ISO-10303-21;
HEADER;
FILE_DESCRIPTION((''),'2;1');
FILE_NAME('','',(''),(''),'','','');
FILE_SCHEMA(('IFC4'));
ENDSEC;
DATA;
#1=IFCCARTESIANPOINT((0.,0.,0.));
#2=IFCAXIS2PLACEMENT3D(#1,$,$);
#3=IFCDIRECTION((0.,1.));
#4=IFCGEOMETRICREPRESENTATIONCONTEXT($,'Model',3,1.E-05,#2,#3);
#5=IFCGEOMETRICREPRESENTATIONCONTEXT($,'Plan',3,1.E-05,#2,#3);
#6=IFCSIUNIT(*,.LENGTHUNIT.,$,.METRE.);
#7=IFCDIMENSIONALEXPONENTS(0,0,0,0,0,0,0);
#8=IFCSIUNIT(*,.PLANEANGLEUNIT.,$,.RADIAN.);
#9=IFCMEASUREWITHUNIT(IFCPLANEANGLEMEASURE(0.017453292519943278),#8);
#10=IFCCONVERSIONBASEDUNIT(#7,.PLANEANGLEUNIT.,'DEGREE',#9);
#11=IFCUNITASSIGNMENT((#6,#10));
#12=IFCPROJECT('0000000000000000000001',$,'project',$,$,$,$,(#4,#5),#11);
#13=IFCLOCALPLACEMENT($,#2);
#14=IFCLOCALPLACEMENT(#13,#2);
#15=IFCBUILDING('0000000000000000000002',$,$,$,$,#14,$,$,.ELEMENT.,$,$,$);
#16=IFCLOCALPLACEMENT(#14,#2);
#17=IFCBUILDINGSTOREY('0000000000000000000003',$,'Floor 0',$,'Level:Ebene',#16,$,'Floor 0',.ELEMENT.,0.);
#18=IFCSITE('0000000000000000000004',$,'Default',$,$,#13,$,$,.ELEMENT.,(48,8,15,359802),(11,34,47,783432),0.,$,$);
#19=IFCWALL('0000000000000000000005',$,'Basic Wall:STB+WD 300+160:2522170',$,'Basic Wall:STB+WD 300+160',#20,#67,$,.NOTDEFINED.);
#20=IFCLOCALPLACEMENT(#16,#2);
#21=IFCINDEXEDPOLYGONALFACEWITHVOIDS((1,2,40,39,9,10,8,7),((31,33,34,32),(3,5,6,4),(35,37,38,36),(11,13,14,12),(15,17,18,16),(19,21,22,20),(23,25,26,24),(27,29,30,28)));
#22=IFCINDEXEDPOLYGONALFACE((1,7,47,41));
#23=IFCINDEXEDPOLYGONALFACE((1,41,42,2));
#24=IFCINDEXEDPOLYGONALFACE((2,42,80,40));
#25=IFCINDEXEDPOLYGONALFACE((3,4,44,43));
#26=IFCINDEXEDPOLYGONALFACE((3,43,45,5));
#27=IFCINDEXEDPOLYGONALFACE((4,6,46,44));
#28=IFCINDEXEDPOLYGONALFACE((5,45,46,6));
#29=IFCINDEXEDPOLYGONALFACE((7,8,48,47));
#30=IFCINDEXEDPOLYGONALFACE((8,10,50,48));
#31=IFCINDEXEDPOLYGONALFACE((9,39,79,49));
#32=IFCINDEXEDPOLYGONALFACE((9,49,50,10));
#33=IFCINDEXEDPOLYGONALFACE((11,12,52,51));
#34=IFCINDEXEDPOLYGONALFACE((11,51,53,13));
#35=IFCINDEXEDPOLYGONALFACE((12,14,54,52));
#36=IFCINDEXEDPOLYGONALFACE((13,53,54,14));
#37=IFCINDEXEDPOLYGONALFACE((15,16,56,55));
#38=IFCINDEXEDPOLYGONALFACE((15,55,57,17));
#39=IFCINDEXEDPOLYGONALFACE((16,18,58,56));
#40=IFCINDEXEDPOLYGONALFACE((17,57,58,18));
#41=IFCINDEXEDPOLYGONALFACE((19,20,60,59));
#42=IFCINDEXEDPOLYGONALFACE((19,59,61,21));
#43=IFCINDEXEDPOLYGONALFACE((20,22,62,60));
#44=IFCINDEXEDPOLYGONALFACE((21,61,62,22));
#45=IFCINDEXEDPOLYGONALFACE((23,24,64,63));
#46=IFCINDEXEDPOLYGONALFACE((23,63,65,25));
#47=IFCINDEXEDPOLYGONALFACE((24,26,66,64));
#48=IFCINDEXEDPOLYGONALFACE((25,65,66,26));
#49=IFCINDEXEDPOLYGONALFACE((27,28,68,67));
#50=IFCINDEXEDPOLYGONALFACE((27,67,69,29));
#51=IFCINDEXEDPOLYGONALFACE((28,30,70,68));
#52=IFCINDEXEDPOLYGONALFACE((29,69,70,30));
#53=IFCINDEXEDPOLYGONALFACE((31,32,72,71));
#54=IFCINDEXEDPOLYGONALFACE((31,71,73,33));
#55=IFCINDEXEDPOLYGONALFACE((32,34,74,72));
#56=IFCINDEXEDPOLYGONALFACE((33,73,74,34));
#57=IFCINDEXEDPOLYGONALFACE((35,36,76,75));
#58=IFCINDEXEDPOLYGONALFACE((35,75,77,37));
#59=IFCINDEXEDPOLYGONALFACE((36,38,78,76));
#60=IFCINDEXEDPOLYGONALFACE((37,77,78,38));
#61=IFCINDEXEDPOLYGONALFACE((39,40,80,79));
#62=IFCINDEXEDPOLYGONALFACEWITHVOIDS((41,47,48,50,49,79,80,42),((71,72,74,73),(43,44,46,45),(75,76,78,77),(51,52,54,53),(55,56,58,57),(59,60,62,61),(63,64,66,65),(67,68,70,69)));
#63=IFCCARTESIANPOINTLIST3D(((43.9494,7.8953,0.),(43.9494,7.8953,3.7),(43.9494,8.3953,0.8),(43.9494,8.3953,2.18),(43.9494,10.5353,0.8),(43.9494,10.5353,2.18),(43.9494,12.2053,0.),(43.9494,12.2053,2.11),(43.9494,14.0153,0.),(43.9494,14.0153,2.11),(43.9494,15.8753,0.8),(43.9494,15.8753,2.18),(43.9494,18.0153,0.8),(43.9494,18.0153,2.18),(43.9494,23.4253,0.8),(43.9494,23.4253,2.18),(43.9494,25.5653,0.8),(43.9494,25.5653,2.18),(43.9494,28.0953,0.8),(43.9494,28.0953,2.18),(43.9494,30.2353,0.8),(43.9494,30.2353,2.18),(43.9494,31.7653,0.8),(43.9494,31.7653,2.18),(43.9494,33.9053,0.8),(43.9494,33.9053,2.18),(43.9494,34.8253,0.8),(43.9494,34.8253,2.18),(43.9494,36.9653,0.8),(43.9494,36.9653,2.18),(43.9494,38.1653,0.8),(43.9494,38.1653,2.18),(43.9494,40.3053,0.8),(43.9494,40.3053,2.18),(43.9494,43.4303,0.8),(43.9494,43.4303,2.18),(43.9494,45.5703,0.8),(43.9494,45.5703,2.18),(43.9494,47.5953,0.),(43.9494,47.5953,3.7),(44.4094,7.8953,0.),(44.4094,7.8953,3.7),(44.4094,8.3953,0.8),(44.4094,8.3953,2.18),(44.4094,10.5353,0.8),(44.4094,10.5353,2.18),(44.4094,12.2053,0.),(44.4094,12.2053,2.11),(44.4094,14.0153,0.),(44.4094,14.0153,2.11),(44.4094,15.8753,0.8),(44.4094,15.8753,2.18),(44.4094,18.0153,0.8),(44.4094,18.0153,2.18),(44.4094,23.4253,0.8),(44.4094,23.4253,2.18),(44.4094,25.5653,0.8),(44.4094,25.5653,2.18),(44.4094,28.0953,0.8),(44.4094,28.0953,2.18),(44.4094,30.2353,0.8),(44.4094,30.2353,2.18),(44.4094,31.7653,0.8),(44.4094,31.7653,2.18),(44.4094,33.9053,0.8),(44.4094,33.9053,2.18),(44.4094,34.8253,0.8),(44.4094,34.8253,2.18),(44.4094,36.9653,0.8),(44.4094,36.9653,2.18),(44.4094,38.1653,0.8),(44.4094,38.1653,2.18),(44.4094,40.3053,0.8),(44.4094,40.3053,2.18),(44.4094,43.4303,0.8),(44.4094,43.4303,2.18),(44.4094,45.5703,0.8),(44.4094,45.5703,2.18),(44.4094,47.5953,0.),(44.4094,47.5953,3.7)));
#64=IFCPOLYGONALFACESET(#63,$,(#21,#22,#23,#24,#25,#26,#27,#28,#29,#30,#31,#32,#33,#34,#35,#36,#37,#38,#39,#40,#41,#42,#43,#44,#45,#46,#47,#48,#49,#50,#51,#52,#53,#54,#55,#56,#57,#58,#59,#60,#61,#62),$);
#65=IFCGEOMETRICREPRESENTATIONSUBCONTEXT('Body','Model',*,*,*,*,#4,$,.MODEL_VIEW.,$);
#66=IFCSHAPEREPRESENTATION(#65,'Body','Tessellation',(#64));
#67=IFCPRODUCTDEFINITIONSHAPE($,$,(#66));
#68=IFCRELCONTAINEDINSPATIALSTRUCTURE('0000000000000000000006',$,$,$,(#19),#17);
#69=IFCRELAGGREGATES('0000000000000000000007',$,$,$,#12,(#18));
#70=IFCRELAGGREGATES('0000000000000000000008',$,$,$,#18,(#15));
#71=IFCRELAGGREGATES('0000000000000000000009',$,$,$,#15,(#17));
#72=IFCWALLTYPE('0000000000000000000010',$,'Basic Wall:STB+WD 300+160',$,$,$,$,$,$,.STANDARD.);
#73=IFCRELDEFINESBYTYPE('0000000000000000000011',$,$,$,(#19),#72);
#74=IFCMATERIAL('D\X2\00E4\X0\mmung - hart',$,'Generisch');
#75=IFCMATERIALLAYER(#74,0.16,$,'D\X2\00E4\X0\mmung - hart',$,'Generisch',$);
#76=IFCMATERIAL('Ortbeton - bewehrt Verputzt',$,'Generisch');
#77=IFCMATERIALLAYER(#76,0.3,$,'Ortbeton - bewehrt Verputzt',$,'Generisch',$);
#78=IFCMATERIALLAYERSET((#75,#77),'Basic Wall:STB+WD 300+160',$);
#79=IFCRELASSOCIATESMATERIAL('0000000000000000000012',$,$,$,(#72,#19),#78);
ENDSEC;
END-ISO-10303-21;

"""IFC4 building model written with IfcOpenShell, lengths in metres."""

from ifc_helpers import new_model, entity, si_unit, converted_unit, direction, frame, frame_2d, origin, place, context, subcontext, project, spatial, rectangle, extrude, material, layer, layer_set, layer_usage, type_object, element, save


model = new_model("IFC4")

# Units and contexts
model_context = context("Model", 3, precision=1e-05, world=origin(), true_north=direction((0.0, 1.0)))
plan_context = context("Plan", 3, precision=1e-05, world=origin(), true_north=direction((0.0, 1.0)))
body_context = subcontext(model_context, "Body", "Model", "MODEL_VIEW")
ifc_project = project(units=[si_unit("LENGTHUNIT", "METRE"), converted_unit("PLANEANGLEUNIT", "DEGREE", entity("IfcPlaneAngleMeasure", 0.017453292519943278), si_unit("PLANEANGLEUNIT", "RADIAN"), dimensions=[0, 0, 0, 0, 0, 0, 0])], contexts=[model_context, plan_context])

# Site, building, storey
site_placement = place(None, origin())
site = spatial("IfcSite", under=ifc_project, at=site_placement, Name="Default", CompositionType="ELEMENT", RefLatitude=(48, 8, 15, 359802), RefLongitude=(11, 34, 47, 783432), RefElevation=0.0)
building_placement = place(site_placement, origin())
building = spatial("IfcBuilding", under=site, at=building_placement, CompositionType="ELEMENT")
storey_placement = place(building_placement, origin())
storey = spatial("IfcBuildingStorey", under=building, at=storey_placement, Name="Floor 0", ObjectType="Level:Ebene", LongName="Floor 0", CompositionType="ELEMENT", Elevation=0.0)

# Shared definitions
ifc_material_1 = material(Name="Ortbeton - bewehrt Verputzt", Category="Generisch")

# Wall, openings
ifc_material_2 = material(Name="Dämmung - hart", Category="Generisch")
ifc_layer_1 = layer(ifc_material_2, 0.16, Name="Dämmung - hart", Category="Generisch")
ifc_layer_2 = layer(ifc_material_1, 0.3, Name="Ortbeton - bewehrt Verputzt", Category="Generisch")
ifc_layer_set_1 = layer_set([ifc_layer_1, ifc_layer_2], Name="Basic Wall:STB+WD 300+160")
ifc_layer_usage_1 = layer_usage(ifc_layer_set_1, "AXIS2", "POSITIVE", -0.23)
wall_type_1 = type_object("IfcWallType", Name="Basic Wall:STB+WD 300+160", PredefinedType="STANDARD", material=ifc_layer_set_1)
wall_1_placement = place(storey_placement, frame((44.1794, 7.8953, 0.0), z_axis=(0.0, 0.0, 1.0), x_axis=(0.0, 1.0, 0.0)))
wall_1 = element("IfcWall", 1, at=wall_1_placement, inside=storey, type_object=wall_type_1, material=ifc_layer_usage_1, Name="Basic Wall:STB+WD 300+160:2522170", ObjectType="Basic Wall:STB+WD 300+160", PredefinedType="NOTDEFINED", context=body_context, shape_type="SweptSolid", body=[
    extrude(rectangle(XDim=39.7, YDim=0.46, at=frame_2d((19.85, 0.0), x_axis=(-1.0, 0.0))), origin(), (0.0, 0.0, 1.0), 3.7),
])
opening_1_placement = place(wall_1_placement, frame((4.31, -0.23, 0.0)))
element("IfcOpeningElement", 2, at=opening_1_placement, cuts=wall_1, PredefinedType="OPENING", context=body_context, shape_type="SweptSolid", body=[
    extrude(rectangle(XDim=2.11, YDim=1.81, at=frame_2d((1.055, 0.905), x_axis=(1.0, 0.0))), frame((0.0, 0.0, 0.0), z_axis=(0.0, 1.0, 0.0), x_axis=(0.0, 0.0, 1.0)), (0.0, 0.0, 1.0), 0.46),
])
opening_2_placement = place(wall_1_placement, frame((-7.8953, 44.1794, 0.8), z_axis=(0.0, 0.0, 1.0), x_axis=(0.0, -1.0, 0.0)))
element("IfcOpeningElement", 3, at=opening_2_placement, cuts=wall_1, PredefinedType="OPENING", context=body_context, shape_type="SweptSolid", body=[
    extrude(rectangle(XDim=1.38, YDim=2.14, at=frame_2d((0.0, 0.0), x_axis=(0.0, 1.0))), frame((45.4734, 44.5003, 0.69), z_axis=(-1.0, 0.0, 0.0), x_axis=(0.0, -1.0, 0.0)), (0.0, 0.0, 1.0), 3.048),
])
opening_3_placement = place(wall_1_placement, frame((-7.8953, 44.1794, 0.8), z_axis=(0.0, 0.0, 1.0), x_axis=(0.0, -1.0, 0.0)))
element("IfcOpeningElement", 4, at=opening_3_placement, cuts=wall_1, PredefinedType="OPENING", context=body_context, shape_type="SweptSolid", body=[
    extrude(rectangle(XDim=1.38, YDim=2.14, at=frame_2d((0.0, 0.0), x_axis=(0.0, 1.0))), frame((45.4734, 39.2353, 0.69), z_axis=(-1.0, 0.0, 0.0), x_axis=(0.0, -1.0, 0.0)), (0.0, 0.0, 1.0), 3.048),
])
opening_4_placement = place(wall_1_placement, frame((-7.8953, 44.1794, 0.8), z_axis=(0.0, 0.0, 1.0), x_axis=(0.0, -1.0, 0.0)))
element("IfcOpeningElement", 5, at=opening_4_placement, cuts=wall_1, PredefinedType="OPENING", context=body_context, shape_type="SweptSolid", body=[
    extrude(rectangle(XDim=1.38, YDim=2.14, at=frame_2d((0.0, 0.0), x_axis=(1.0, 0.0))), frame((45.9334, 35.8953, 0.69), z_axis=(-1.0, 0.0, 0.0), x_axis=(0.0, 0.0, 1.0)), (0.0, 0.0, 1.0), 3.048),
])
opening_5_placement = place(wall_1_placement, frame((-7.8953, 44.1794, 0.8), z_axis=(0.0, 0.0, 1.0), x_axis=(0.0, -1.0, 0.0)))
element("IfcOpeningElement", 6, at=opening_5_placement, cuts=wall_1, PredefinedType="OPENING", context=body_context, shape_type="SweptSolid", body=[
    extrude(rectangle(XDim=1.38, YDim=2.14, at=frame_2d((0.0, 0.0), x_axis=(1.0, 0.0))), frame((45.9334, 32.8353, 0.69), z_axis=(-1.0, 0.0, 0.0), x_axis=(0.0, 0.0, 1.0)), (0.0, 0.0, 1.0), 3.048),
])
opening_6_placement = place(wall_1_placement, frame((-7.8953, 44.1794, 0.8), z_axis=(0.0, 0.0, 1.0), x_axis=(0.0, -1.0, 0.0)))
element("IfcOpeningElement", 7, at=opening_6_placement, cuts=wall_1, PredefinedType="OPENING", context=body_context, shape_type="SweptSolid", body=[
    extrude(rectangle(XDim=1.38, YDim=2.14, at=frame_2d((0.0, 0.0), x_axis=(0.0, 1.0))), frame((45.4734, 29.1653, 0.69), z_axis=(-1.0, 0.0, 0.0), x_axis=(0.0, -1.0, 0.0)), (0.0, 0.0, 1.0), 3.048),
])
opening_7_placement = place(wall_1_placement, frame((-7.8953, 44.1794, 0.8), z_axis=(0.0, 0.0, 1.0), x_axis=(0.0, -1.0, 0.0)))
element("IfcOpeningElement", 8, at=opening_7_placement, cuts=wall_1, PredefinedType="OPENING", context=body_context, shape_type="SweptSolid", body=[
    extrude(rectangle(XDim=1.38, YDim=2.14, at=frame_2d((0.0, 0.0), x_axis=(1.0, 0.0))), frame((45.9334, 24.4953, 0.69), z_axis=(-1.0, 0.0, 0.0), x_axis=(0.0, 0.0, 1.0)), (0.0, 0.0, 1.0), 3.048),
])
opening_8_placement = place(wall_1_placement, frame((-7.8953, 44.1794, 0.8), z_axis=(0.0, 0.0, 1.0), x_axis=(0.0, -1.0, 0.0)))
element("IfcOpeningElement", 9, at=opening_8_placement, cuts=wall_1, PredefinedType="OPENING", context=body_context, shape_type="SweptSolid", body=[
    extrude(rectangle(XDim=1.38, YDim=2.14, at=frame_2d((0.0, 0.0), x_axis=(0.0, 1.0))), frame((45.4734, 16.9453, 0.69), z_axis=(-1.0, 0.0, 0.0), x_axis=(0.0, -1.0, 0.0)), (0.0, 0.0, 1.0), 3.048),
])
opening_9_placement = place(wall_1_placement, frame((-7.8953, 44.1794, 0.8), z_axis=(0.0, 0.0, 1.0), x_axis=(0.0, -1.0, 0.0)))
element("IfcOpeningElement", 10, at=opening_9_placement, cuts=wall_1, PredefinedType="OPENING", context=body_context, shape_type="SweptSolid", body=[
    extrude(rectangle(XDim=1.38, YDim=2.14, at=frame_2d((0.0, 0.0), x_axis=(0.0, 1.0))), frame((45.4734, 9.4653, 0.69), z_axis=(-1.0, 0.0, 0.0), x_axis=(0.0, -1.0, 0.0)), (0.0, 0.0, 1.0), 3.048),
])

save(model, "model.ifc")
